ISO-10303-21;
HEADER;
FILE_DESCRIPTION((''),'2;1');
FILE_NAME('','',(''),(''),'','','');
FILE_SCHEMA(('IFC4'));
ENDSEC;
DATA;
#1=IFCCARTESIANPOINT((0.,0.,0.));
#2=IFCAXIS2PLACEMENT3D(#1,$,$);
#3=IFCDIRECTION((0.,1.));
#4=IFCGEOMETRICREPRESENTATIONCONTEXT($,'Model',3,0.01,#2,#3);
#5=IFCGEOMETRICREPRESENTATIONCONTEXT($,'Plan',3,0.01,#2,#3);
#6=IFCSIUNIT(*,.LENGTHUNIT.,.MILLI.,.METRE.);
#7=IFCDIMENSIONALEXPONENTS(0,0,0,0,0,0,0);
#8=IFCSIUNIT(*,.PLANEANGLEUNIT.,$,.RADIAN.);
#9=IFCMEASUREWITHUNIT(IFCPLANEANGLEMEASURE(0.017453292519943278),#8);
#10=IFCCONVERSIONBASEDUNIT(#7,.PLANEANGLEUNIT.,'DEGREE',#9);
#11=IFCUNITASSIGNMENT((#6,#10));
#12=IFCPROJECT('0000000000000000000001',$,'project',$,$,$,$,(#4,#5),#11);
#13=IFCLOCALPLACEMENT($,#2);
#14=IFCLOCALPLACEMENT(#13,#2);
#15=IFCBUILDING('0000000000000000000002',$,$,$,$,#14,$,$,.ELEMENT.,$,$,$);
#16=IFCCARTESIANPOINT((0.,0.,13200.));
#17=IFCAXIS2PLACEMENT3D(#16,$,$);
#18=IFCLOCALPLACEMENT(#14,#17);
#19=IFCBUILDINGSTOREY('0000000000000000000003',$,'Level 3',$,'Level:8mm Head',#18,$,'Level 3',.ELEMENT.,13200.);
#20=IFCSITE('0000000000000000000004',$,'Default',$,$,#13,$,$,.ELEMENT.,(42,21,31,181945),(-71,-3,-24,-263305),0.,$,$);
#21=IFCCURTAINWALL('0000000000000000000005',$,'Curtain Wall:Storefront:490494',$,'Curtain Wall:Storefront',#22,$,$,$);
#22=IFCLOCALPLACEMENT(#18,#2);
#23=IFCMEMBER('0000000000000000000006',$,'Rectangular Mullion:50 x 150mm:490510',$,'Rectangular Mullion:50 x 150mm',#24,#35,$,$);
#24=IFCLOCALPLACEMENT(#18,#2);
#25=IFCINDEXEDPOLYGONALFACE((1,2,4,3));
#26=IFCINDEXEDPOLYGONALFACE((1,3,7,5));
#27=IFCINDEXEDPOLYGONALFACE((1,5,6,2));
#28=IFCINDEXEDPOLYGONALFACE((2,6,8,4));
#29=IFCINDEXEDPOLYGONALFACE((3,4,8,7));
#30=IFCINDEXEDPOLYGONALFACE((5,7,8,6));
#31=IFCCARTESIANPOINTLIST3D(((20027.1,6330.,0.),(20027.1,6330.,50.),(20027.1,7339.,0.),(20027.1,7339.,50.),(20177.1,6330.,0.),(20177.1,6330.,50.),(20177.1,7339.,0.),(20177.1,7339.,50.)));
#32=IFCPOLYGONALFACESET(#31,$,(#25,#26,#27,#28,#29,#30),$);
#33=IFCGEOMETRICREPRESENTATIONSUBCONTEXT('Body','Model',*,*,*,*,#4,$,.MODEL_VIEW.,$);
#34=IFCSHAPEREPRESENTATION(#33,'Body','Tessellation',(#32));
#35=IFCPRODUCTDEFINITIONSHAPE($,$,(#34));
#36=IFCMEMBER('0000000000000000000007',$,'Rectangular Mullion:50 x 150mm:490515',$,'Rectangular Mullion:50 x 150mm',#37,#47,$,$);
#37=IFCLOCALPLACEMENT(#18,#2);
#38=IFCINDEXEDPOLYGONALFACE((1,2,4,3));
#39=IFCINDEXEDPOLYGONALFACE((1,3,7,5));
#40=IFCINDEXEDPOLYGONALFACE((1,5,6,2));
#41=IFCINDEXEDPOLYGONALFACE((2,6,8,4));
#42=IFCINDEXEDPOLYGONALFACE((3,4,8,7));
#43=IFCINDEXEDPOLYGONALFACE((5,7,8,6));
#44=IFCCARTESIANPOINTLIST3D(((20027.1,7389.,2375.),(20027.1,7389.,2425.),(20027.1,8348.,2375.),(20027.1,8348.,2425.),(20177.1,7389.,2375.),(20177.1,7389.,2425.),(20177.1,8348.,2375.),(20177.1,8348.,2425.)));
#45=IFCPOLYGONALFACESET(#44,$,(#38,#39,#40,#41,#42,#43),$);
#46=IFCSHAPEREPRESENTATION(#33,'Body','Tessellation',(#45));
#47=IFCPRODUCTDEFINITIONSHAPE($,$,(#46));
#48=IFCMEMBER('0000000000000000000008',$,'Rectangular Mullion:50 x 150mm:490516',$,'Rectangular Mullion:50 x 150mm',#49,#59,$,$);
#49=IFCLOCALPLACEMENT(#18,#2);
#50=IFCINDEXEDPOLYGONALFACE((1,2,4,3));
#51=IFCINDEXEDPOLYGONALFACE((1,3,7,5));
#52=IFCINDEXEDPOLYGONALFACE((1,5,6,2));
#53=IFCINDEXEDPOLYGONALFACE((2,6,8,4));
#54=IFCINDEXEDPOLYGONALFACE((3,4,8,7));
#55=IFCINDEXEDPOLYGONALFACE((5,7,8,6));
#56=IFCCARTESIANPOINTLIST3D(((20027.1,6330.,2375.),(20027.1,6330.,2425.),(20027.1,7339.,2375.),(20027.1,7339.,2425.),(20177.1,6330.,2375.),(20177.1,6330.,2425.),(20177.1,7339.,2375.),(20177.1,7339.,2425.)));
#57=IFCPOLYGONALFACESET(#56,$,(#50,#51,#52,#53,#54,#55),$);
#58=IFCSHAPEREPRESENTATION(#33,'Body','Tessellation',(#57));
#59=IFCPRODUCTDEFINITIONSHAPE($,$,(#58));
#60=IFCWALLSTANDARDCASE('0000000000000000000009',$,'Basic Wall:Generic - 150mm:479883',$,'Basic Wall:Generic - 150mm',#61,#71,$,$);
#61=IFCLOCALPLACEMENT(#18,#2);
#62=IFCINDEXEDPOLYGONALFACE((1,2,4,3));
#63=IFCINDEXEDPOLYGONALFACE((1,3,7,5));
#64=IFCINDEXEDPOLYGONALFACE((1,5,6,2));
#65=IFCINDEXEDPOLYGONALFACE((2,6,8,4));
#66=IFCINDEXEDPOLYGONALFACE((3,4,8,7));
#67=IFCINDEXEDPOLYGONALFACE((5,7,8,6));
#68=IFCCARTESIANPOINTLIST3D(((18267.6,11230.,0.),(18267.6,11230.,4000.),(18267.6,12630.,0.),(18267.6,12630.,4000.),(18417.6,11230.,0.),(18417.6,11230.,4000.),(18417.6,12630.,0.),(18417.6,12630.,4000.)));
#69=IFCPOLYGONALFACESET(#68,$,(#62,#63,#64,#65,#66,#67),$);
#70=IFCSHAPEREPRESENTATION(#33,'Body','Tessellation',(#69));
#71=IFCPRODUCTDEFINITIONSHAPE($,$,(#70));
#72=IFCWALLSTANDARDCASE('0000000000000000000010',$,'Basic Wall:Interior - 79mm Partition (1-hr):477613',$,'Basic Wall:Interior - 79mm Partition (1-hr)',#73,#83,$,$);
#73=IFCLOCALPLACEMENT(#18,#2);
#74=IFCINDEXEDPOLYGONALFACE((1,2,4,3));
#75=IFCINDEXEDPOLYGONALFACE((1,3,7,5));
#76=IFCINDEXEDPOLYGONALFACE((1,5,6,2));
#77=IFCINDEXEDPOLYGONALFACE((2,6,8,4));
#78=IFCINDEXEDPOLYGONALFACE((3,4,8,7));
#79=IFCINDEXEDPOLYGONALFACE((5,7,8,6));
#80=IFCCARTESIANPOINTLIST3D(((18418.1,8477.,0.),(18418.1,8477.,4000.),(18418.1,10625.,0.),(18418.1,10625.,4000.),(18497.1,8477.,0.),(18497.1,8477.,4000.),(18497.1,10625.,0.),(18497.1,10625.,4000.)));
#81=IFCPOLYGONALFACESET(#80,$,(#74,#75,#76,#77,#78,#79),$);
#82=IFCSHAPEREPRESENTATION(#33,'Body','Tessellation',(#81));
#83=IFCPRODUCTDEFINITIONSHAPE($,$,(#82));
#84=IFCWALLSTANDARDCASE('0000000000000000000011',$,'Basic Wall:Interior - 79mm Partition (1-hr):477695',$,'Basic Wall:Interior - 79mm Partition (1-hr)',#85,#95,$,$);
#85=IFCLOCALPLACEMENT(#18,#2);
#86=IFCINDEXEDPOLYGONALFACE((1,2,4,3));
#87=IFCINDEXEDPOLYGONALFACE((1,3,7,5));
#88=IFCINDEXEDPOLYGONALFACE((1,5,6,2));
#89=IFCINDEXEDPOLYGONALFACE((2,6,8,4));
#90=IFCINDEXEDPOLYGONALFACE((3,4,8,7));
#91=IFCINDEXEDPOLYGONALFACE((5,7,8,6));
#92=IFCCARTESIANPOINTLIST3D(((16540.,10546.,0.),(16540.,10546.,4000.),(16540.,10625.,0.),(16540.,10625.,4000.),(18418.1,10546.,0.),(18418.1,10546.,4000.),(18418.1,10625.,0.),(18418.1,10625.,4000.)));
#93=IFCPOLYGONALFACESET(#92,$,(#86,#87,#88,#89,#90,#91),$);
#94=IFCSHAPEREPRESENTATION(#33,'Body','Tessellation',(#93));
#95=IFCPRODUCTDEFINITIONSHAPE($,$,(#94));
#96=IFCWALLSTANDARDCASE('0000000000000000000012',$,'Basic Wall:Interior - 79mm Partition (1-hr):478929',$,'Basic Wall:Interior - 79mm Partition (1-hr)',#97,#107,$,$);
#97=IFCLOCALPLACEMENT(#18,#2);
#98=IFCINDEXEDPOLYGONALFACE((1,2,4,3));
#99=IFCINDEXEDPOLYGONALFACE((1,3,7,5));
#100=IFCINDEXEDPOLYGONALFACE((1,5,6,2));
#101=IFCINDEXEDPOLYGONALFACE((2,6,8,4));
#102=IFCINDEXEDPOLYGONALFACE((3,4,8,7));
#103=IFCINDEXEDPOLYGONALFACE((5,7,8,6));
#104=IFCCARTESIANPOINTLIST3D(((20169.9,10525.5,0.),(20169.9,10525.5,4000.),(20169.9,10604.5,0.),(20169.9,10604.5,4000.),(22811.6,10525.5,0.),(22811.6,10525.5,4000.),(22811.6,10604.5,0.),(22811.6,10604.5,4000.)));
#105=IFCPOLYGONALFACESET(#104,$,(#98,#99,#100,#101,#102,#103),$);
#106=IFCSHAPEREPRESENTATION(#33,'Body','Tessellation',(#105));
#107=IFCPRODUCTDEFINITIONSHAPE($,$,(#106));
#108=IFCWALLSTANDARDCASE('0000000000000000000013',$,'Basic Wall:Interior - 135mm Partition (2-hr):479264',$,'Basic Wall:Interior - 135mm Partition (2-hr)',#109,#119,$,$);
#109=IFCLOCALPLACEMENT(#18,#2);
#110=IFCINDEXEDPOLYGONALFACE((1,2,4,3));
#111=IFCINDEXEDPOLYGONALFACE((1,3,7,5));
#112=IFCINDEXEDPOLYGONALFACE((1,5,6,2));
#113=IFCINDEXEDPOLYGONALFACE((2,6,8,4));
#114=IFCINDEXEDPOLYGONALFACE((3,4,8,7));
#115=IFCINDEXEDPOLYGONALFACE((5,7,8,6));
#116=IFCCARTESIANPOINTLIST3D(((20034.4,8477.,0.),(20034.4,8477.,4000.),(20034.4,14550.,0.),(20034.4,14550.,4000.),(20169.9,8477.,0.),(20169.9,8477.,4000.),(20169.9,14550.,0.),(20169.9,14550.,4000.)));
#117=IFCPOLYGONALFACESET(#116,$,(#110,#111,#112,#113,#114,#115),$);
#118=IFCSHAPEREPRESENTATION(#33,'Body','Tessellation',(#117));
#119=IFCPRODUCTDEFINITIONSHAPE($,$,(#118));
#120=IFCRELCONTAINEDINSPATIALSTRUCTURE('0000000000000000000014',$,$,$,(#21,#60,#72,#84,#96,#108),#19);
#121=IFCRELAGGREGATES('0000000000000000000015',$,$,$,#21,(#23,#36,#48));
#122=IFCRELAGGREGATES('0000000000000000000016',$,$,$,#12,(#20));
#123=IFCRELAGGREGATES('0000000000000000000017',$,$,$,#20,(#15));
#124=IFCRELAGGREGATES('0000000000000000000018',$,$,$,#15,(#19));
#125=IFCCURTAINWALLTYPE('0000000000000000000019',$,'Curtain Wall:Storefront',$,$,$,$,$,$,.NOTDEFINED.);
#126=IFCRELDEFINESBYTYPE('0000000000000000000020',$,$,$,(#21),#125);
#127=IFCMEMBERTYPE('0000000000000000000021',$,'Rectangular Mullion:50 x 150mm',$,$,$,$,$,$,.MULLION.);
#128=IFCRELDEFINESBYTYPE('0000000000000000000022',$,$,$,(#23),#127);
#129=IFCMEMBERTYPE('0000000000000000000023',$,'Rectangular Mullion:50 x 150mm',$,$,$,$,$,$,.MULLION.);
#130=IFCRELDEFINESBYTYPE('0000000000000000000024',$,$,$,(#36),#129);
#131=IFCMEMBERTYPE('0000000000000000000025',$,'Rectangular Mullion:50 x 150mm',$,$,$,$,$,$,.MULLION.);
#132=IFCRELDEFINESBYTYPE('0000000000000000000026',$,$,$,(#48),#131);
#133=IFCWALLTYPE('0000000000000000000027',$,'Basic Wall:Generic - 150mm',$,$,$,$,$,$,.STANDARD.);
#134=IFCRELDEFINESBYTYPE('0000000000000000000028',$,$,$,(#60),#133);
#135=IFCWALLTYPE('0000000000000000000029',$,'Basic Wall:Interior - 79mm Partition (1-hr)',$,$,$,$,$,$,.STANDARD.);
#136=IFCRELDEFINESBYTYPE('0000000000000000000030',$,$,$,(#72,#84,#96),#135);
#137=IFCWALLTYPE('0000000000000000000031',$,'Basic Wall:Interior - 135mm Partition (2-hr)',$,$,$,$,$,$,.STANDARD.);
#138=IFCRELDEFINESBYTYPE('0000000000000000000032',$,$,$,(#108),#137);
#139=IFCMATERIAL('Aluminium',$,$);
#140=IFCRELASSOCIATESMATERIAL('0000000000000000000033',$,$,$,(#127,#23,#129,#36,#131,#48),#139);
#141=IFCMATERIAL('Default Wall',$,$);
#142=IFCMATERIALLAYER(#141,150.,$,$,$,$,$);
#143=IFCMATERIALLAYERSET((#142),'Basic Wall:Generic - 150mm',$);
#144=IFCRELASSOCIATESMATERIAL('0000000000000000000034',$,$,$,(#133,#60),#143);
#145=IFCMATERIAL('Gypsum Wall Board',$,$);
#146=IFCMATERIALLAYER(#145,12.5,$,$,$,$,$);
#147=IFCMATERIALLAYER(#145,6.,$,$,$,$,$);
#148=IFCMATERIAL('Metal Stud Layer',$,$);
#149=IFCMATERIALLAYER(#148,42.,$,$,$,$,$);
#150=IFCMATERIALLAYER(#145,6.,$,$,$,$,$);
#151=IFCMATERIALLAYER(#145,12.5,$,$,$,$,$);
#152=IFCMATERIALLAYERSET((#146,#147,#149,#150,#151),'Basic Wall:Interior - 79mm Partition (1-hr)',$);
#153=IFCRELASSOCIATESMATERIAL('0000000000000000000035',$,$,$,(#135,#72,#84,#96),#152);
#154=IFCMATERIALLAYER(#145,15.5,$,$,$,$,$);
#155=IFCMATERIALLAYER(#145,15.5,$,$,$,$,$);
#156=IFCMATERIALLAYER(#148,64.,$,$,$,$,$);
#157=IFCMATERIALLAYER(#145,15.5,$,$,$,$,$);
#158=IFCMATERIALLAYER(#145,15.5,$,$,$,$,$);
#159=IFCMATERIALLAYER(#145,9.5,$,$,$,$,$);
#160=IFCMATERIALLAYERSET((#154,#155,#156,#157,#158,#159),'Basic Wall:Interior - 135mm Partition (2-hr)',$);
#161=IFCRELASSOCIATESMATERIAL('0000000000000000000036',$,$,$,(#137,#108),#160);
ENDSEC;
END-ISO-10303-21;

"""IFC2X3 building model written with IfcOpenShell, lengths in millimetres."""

from ifc_helpers import new_model, entity, si_unit, converted_unit, direction, frame, frame_2d, origin, origin_2d_with_axis, place, context, subcontext, project, spatial, rectangle, extrude, source, transform, mapped, material, layer, layer_set, layer_usage, type_object, type_shapes, element, aggregate, save


model = new_model("IFC2X3")

# Units and contexts
model_context = context("Model", 3, precision=0.01, world=origin(), true_north=direction((0.0, 1.0)))
plan_context = context("Plan", 3, precision=0.01, world=origin(), true_north=direction((0.0, 1.0)))
body_context = subcontext(model_context, "Body", "Model", "MODEL_VIEW")
ifc_project = project(units=[si_unit("LENGTHUNIT", "METRE", prefix="MILLI"), converted_unit("PLANEANGLEUNIT", "DEGREE", entity("IfcPlaneAngleMeasure", 0.017453292519943278), si_unit("PLANEANGLEUNIT", "RADIAN"), dimensions=[0, 0, 0, 0, 0, 0, 0])], contexts=[model_context, plan_context])

# Site, building, storey
site_placement = place(None, origin())
site = spatial("IfcSite", under=ifc_project, at=site_placement, Name="Default", CompositionType="ELEMENT", RefLatitude=(42, 21, 31, 181945), RefLongitude=(-71, -3, -24, -263305), RefElevation=0.0)
building_placement = place(site_placement, origin())
building = spatial("IfcBuilding", under=site, at=building_placement, CompositionType="ELEMENT")
storey_placement = place(building_placement, frame((0.0, 0.0, 13200.0)))
storey = spatial("IfcBuildingStorey", under=building, at=storey_placement, Name="Level 3", ObjectType="Level:8mm Head", LongName="Level 3", CompositionType="ELEMENT", Elevation=13200.0)

# Curtain wall
curtain_wall_type = type_object("IfcCurtainWallType", Name="Curtain Wall:Storefront", PredefinedType="NOTDEFINED")
curtain_wall_1_placement = place(storey_placement, frame((0.0, 0.0, -13200.0)))
curtain_wall_1 = element("IfcCurtainWall", 1, at=curtain_wall_1_placement, inside=storey, type_object=curtain_wall_type, Name="Curtain Wall:Storefront:490494", ObjectType="Curtain Wall:Storefront")
ifc_material_1 = material(Name="Aluminium")

# Members
member_type_1 = type_object("IfcMemberType", Name="Rectangular Mullion:50 x 150mm", PredefinedType="MULLION", material=ifc_material_1)
shared_shape_1 = source(origin(), body_context, "Body", "SweptSolid", [
    extrude(rectangle(XDim=50.0, YDim=150.0, at=origin_2d_with_axis()), frame((-25.0, 0.0, -1009.0), z_axis=(0.0, 0.0, 1.0), x_axis=(-1.0, 0.0, 0.0)), (0.0, 0.0, 1.0), 1009.0),
])
type_shapes(member_type_1, [shared_shape_1])
member_1_placement = place(curtain_wall_1_placement, frame((20102.1, 7339.0, 13200.0), z_axis=(0.0, 1.0, 0.0), x_axis=(0.0, 0.0, -1.0)))
member_1 = element("IfcMember", 2, at=member_1_placement, type_object=member_type_1, material=ifc_material_1, Name="Rectangular Mullion:50 x 150mm:490510", ObjectType="Rectangular Mullion:50 x 150mm", context=body_context, shape_type="MappedRepresentation", body=[
    mapped(shared_shape_1, transform((0.0, 0.0, 0.0), scale=1.0)),
])
member_type_2 = type_object("IfcMemberType", Name="Rectangular Mullion:50 x 150mm", PredefinedType="MULLION", material=ifc_material_1)
shared_shape_2 = source(origin(), body_context, "Body", "SweptSolid", [
    extrude(rectangle(XDim=50.0, YDim=150.0, at=origin_2d_with_axis()), frame((0.0, 0.0, -959.0), z_axis=(0.0, 0.0, 1.0), x_axis=(-1.0, 0.0, 0.0)), (0.0, 0.0, 1.0), 959.0),
])
type_shapes(member_type_2, [shared_shape_2])
member_2_placement = place(curtain_wall_1_placement, frame((20102.1, 7389.0, 15600.0), z_axis=(0.0, -1.0, 0.0), x_axis=(0.0, 0.0, 1.0)))
member_2 = element("IfcMember", 3, at=member_2_placement, type_object=member_type_2, material=ifc_material_1, Name="Rectangular Mullion:50 x 150mm:490515", ObjectType="Rectangular Mullion:50 x 150mm", context=body_context, shape_type="MappedRepresentation", body=[
    mapped(shared_shape_2, transform((0.0, 0.0, 0.0), scale=1.0)),
])
member_type_3 = type_object("IfcMemberType", Name="Rectangular Mullion:50 x 150mm", PredefinedType="MULLION", material=ifc_material_1)
shared_shape_3 = source(origin(), body_context, "Body", "SweptSolid", [
    extrude(rectangle(XDim=50.0, YDim=150.0, at=origin_2d_with_axis()), frame((0.0, 0.0, -1009.0), z_axis=(0.0, 0.0, 1.0), x_axis=(-1.0, 0.0, 0.0)), (0.0, 0.0, 1.0), 1009.0),
])
type_shapes(member_type_3, [shared_shape_3])
member_3_placement = place(curtain_wall_1_placement, frame((20102.1, 6330.0, 15600.0), z_axis=(0.0, -1.0, 0.0), x_axis=(0.0, 0.0, 1.0)))
member_3 = element("IfcMember", 4, at=member_3_placement, type_object=member_type_3, material=ifc_material_1, Name="Rectangular Mullion:50 x 150mm:490516", ObjectType="Rectangular Mullion:50 x 150mm", context=body_context, shape_type="MappedRepresentation", body=[
    mapped(shared_shape_3, transform((0.0, 0.0, 0.0), scale=1.0)),
])

# Walls
ifc_material_2 = material(Name="Default Wall")
ifc_layer_1 = layer(ifc_material_2, 150.0)
ifc_layer_set_1 = layer_set([ifc_layer_1], Name="Basic Wall:Generic - 150mm")
ifc_layer_usage_1 = layer_usage(ifc_layer_set_1, "AXIS2", "NEGATIVE", 75.0)
wall_type_1 = type_object("IfcWallType", Name="Basic Wall:Generic - 150mm", PredefinedType="STANDARD", material=ifc_layer_set_1)
wall_1_placement = place(storey_placement, frame((18342.6, 12630.0, 0.0), z_axis=(0.0, 0.0, 1.0), x_axis=(0.0, -1.0, 0.0)))
element("IfcWallStandardCase", 5, at=wall_1_placement, inside=storey, type_object=wall_type_1, material=ifc_layer_usage_1, Name="Basic Wall:Generic - 150mm:479883", ObjectType="Basic Wall:Generic - 150mm", context=body_context, shape_type="SweptSolid", body=[
    extrude(rectangle(XDim=1400.0, YDim=150.0, at=frame_2d((700.0, 0.0), x_axis=(-1.0, 0.0))), origin(), (0.0, 0.0, 1.0), 4000.0),
])
ifc_material_3 = material(Name="Gypsum Wall Board")
ifc_layer_2 = layer(ifc_material_3, 12.5)
ifc_layer_3 = layer(ifc_material_3, 6.0)
ifc_material_4 = material(Name="Metal Stud Layer")
ifc_layer_4 = layer(ifc_material_4, 42.0)
ifc_layer_5 = layer(ifc_material_3, 6.0)
ifc_layer_6 = layer(ifc_material_3, 12.5)
ifc_layer_set_2 = layer_set([ifc_layer_2, ifc_layer_3, ifc_layer_4, ifc_layer_5, ifc_layer_6], Name="Basic Wall:Interior - 79mm Partition (1-hr)")
ifc_layer_usage_2 = layer_usage(ifc_layer_set_2, "AXIS2", "NEGATIVE", 39.5)
wall_type_2 = type_object("IfcWallType", Name="Basic Wall:Interior - 79mm Partition (1-hr)", PredefinedType="STANDARD", material=ifc_layer_set_2)
wall_2_placement = place(storey_placement, frame((18457.6, 8477.0, 0.0), z_axis=(0.0, 0.0, 1.0), x_axis=(0.0, 1.0, 0.0)))
element("IfcWallStandardCase", 6, at=wall_2_placement, inside=storey, type_object=wall_type_2, material=ifc_layer_usage_2, Name="Basic Wall:Interior - 79mm Partition (1-hr):477613", ObjectType="Basic Wall:Interior - 79mm Partition (1-hr)", context=body_context, shape_type="SweptSolid", body=[
    extrude(rectangle(XDim=2148.0, YDim=79.0, at=frame_2d((1074.0, 0.0), x_axis=(-1.0, 0.0))), origin(), (0.0, 0.0, 1.0), 4000.0),
])
wall_3_placement = place(storey_placement, frame((18418.1, 10585.5, 0.0), z_axis=(0.0, 0.0, 1.0), x_axis=(-1.0, 0.0, 0.0)))
element("IfcWallStandardCase", 7, at=wall_3_placement, inside=storey, type_object=wall_type_2, material=ifc_layer_usage_2, Name="Basic Wall:Interior - 79mm Partition (1-hr):477695", ObjectType="Basic Wall:Interior - 79mm Partition (1-hr)", context=body_context, shape_type="SweptSolid", body=[
    extrude(rectangle(XDim=1878.1, YDim=79.0, at=frame_2d((939.1, 0.0), x_axis=(-1.0, 0.0))), origin(), (0.0, 0.0, 1.0), 4000.0),
])
wall_4_placement = place(storey_placement, frame((20169.9, 10565.0, 0.0)))
element("IfcWallStandardCase", 8, at=wall_4_placement, inside=storey, type_object=wall_type_2, material=ifc_layer_usage_2, Name="Basic Wall:Interior - 79mm Partition (1-hr):478929", ObjectType="Basic Wall:Interior - 79mm Partition (1-hr)", context=body_context, shape_type="SweptSolid", body=[
    extrude(rectangle(XDim=2641.7, YDim=79.0, at=frame_2d((1320.9, 0.0), x_axis=(-1.0, 0.0))), origin(), (0.0, 0.0, 1.0), 4000.0),
])
ifc_layer_7 = layer(ifc_material_3, 15.5)
ifc_layer_8 = layer(ifc_material_3, 15.5)
ifc_layer_9 = layer(ifc_material_4, 64.0)
ifc_layer_10 = layer(ifc_material_3, 15.5)
ifc_layer_11 = layer(ifc_material_3, 15.5)
ifc_layer_12 = layer(ifc_material_3, 9.5)
ifc_layer_set_3 = layer_set([ifc_layer_7, ifc_layer_8, ifc_layer_9, ifc_layer_10, ifc_layer_11, ifc_layer_12], Name="Basic Wall:Interior - 135mm Partition (2-hr)")
ifc_layer_usage_3 = layer_usage(ifc_layer_set_3, "AXIS2", "NEGATIVE", 67.8)
wall_type_3 = type_object("IfcWallType", Name="Basic Wall:Interior - 135mm Partition (2-hr)", PredefinedType="STANDARD", material=ifc_layer_set_3)
wall_5_placement = place(storey_placement, frame((20102.1, 8477.0, 0.0), z_axis=(0.0, 0.0, 1.0), x_axis=(0.0, 1.0, 0.0)))
element("IfcWallStandardCase", 9, at=wall_5_placement, inside=storey, type_object=wall_type_3, material=ifc_layer_usage_3, Name="Basic Wall:Interior - 135mm Partition (2-hr):479264", ObjectType="Basic Wall:Interior - 135mm Partition (2-hr)", context=body_context, shape_type="SweptSolid", body=[
    extrude(rectangle(XDim=6073.0, YDim=135.5, at=frame_2d((3036.5, 0.0), x_axis=(-1.0, 0.0))), origin(), (0.0, 0.0, 1.0), 4000.0),
])

aggregate(curtain_wall_1, [member_1, member_2, member_3])

save(model, "model.ifc")
